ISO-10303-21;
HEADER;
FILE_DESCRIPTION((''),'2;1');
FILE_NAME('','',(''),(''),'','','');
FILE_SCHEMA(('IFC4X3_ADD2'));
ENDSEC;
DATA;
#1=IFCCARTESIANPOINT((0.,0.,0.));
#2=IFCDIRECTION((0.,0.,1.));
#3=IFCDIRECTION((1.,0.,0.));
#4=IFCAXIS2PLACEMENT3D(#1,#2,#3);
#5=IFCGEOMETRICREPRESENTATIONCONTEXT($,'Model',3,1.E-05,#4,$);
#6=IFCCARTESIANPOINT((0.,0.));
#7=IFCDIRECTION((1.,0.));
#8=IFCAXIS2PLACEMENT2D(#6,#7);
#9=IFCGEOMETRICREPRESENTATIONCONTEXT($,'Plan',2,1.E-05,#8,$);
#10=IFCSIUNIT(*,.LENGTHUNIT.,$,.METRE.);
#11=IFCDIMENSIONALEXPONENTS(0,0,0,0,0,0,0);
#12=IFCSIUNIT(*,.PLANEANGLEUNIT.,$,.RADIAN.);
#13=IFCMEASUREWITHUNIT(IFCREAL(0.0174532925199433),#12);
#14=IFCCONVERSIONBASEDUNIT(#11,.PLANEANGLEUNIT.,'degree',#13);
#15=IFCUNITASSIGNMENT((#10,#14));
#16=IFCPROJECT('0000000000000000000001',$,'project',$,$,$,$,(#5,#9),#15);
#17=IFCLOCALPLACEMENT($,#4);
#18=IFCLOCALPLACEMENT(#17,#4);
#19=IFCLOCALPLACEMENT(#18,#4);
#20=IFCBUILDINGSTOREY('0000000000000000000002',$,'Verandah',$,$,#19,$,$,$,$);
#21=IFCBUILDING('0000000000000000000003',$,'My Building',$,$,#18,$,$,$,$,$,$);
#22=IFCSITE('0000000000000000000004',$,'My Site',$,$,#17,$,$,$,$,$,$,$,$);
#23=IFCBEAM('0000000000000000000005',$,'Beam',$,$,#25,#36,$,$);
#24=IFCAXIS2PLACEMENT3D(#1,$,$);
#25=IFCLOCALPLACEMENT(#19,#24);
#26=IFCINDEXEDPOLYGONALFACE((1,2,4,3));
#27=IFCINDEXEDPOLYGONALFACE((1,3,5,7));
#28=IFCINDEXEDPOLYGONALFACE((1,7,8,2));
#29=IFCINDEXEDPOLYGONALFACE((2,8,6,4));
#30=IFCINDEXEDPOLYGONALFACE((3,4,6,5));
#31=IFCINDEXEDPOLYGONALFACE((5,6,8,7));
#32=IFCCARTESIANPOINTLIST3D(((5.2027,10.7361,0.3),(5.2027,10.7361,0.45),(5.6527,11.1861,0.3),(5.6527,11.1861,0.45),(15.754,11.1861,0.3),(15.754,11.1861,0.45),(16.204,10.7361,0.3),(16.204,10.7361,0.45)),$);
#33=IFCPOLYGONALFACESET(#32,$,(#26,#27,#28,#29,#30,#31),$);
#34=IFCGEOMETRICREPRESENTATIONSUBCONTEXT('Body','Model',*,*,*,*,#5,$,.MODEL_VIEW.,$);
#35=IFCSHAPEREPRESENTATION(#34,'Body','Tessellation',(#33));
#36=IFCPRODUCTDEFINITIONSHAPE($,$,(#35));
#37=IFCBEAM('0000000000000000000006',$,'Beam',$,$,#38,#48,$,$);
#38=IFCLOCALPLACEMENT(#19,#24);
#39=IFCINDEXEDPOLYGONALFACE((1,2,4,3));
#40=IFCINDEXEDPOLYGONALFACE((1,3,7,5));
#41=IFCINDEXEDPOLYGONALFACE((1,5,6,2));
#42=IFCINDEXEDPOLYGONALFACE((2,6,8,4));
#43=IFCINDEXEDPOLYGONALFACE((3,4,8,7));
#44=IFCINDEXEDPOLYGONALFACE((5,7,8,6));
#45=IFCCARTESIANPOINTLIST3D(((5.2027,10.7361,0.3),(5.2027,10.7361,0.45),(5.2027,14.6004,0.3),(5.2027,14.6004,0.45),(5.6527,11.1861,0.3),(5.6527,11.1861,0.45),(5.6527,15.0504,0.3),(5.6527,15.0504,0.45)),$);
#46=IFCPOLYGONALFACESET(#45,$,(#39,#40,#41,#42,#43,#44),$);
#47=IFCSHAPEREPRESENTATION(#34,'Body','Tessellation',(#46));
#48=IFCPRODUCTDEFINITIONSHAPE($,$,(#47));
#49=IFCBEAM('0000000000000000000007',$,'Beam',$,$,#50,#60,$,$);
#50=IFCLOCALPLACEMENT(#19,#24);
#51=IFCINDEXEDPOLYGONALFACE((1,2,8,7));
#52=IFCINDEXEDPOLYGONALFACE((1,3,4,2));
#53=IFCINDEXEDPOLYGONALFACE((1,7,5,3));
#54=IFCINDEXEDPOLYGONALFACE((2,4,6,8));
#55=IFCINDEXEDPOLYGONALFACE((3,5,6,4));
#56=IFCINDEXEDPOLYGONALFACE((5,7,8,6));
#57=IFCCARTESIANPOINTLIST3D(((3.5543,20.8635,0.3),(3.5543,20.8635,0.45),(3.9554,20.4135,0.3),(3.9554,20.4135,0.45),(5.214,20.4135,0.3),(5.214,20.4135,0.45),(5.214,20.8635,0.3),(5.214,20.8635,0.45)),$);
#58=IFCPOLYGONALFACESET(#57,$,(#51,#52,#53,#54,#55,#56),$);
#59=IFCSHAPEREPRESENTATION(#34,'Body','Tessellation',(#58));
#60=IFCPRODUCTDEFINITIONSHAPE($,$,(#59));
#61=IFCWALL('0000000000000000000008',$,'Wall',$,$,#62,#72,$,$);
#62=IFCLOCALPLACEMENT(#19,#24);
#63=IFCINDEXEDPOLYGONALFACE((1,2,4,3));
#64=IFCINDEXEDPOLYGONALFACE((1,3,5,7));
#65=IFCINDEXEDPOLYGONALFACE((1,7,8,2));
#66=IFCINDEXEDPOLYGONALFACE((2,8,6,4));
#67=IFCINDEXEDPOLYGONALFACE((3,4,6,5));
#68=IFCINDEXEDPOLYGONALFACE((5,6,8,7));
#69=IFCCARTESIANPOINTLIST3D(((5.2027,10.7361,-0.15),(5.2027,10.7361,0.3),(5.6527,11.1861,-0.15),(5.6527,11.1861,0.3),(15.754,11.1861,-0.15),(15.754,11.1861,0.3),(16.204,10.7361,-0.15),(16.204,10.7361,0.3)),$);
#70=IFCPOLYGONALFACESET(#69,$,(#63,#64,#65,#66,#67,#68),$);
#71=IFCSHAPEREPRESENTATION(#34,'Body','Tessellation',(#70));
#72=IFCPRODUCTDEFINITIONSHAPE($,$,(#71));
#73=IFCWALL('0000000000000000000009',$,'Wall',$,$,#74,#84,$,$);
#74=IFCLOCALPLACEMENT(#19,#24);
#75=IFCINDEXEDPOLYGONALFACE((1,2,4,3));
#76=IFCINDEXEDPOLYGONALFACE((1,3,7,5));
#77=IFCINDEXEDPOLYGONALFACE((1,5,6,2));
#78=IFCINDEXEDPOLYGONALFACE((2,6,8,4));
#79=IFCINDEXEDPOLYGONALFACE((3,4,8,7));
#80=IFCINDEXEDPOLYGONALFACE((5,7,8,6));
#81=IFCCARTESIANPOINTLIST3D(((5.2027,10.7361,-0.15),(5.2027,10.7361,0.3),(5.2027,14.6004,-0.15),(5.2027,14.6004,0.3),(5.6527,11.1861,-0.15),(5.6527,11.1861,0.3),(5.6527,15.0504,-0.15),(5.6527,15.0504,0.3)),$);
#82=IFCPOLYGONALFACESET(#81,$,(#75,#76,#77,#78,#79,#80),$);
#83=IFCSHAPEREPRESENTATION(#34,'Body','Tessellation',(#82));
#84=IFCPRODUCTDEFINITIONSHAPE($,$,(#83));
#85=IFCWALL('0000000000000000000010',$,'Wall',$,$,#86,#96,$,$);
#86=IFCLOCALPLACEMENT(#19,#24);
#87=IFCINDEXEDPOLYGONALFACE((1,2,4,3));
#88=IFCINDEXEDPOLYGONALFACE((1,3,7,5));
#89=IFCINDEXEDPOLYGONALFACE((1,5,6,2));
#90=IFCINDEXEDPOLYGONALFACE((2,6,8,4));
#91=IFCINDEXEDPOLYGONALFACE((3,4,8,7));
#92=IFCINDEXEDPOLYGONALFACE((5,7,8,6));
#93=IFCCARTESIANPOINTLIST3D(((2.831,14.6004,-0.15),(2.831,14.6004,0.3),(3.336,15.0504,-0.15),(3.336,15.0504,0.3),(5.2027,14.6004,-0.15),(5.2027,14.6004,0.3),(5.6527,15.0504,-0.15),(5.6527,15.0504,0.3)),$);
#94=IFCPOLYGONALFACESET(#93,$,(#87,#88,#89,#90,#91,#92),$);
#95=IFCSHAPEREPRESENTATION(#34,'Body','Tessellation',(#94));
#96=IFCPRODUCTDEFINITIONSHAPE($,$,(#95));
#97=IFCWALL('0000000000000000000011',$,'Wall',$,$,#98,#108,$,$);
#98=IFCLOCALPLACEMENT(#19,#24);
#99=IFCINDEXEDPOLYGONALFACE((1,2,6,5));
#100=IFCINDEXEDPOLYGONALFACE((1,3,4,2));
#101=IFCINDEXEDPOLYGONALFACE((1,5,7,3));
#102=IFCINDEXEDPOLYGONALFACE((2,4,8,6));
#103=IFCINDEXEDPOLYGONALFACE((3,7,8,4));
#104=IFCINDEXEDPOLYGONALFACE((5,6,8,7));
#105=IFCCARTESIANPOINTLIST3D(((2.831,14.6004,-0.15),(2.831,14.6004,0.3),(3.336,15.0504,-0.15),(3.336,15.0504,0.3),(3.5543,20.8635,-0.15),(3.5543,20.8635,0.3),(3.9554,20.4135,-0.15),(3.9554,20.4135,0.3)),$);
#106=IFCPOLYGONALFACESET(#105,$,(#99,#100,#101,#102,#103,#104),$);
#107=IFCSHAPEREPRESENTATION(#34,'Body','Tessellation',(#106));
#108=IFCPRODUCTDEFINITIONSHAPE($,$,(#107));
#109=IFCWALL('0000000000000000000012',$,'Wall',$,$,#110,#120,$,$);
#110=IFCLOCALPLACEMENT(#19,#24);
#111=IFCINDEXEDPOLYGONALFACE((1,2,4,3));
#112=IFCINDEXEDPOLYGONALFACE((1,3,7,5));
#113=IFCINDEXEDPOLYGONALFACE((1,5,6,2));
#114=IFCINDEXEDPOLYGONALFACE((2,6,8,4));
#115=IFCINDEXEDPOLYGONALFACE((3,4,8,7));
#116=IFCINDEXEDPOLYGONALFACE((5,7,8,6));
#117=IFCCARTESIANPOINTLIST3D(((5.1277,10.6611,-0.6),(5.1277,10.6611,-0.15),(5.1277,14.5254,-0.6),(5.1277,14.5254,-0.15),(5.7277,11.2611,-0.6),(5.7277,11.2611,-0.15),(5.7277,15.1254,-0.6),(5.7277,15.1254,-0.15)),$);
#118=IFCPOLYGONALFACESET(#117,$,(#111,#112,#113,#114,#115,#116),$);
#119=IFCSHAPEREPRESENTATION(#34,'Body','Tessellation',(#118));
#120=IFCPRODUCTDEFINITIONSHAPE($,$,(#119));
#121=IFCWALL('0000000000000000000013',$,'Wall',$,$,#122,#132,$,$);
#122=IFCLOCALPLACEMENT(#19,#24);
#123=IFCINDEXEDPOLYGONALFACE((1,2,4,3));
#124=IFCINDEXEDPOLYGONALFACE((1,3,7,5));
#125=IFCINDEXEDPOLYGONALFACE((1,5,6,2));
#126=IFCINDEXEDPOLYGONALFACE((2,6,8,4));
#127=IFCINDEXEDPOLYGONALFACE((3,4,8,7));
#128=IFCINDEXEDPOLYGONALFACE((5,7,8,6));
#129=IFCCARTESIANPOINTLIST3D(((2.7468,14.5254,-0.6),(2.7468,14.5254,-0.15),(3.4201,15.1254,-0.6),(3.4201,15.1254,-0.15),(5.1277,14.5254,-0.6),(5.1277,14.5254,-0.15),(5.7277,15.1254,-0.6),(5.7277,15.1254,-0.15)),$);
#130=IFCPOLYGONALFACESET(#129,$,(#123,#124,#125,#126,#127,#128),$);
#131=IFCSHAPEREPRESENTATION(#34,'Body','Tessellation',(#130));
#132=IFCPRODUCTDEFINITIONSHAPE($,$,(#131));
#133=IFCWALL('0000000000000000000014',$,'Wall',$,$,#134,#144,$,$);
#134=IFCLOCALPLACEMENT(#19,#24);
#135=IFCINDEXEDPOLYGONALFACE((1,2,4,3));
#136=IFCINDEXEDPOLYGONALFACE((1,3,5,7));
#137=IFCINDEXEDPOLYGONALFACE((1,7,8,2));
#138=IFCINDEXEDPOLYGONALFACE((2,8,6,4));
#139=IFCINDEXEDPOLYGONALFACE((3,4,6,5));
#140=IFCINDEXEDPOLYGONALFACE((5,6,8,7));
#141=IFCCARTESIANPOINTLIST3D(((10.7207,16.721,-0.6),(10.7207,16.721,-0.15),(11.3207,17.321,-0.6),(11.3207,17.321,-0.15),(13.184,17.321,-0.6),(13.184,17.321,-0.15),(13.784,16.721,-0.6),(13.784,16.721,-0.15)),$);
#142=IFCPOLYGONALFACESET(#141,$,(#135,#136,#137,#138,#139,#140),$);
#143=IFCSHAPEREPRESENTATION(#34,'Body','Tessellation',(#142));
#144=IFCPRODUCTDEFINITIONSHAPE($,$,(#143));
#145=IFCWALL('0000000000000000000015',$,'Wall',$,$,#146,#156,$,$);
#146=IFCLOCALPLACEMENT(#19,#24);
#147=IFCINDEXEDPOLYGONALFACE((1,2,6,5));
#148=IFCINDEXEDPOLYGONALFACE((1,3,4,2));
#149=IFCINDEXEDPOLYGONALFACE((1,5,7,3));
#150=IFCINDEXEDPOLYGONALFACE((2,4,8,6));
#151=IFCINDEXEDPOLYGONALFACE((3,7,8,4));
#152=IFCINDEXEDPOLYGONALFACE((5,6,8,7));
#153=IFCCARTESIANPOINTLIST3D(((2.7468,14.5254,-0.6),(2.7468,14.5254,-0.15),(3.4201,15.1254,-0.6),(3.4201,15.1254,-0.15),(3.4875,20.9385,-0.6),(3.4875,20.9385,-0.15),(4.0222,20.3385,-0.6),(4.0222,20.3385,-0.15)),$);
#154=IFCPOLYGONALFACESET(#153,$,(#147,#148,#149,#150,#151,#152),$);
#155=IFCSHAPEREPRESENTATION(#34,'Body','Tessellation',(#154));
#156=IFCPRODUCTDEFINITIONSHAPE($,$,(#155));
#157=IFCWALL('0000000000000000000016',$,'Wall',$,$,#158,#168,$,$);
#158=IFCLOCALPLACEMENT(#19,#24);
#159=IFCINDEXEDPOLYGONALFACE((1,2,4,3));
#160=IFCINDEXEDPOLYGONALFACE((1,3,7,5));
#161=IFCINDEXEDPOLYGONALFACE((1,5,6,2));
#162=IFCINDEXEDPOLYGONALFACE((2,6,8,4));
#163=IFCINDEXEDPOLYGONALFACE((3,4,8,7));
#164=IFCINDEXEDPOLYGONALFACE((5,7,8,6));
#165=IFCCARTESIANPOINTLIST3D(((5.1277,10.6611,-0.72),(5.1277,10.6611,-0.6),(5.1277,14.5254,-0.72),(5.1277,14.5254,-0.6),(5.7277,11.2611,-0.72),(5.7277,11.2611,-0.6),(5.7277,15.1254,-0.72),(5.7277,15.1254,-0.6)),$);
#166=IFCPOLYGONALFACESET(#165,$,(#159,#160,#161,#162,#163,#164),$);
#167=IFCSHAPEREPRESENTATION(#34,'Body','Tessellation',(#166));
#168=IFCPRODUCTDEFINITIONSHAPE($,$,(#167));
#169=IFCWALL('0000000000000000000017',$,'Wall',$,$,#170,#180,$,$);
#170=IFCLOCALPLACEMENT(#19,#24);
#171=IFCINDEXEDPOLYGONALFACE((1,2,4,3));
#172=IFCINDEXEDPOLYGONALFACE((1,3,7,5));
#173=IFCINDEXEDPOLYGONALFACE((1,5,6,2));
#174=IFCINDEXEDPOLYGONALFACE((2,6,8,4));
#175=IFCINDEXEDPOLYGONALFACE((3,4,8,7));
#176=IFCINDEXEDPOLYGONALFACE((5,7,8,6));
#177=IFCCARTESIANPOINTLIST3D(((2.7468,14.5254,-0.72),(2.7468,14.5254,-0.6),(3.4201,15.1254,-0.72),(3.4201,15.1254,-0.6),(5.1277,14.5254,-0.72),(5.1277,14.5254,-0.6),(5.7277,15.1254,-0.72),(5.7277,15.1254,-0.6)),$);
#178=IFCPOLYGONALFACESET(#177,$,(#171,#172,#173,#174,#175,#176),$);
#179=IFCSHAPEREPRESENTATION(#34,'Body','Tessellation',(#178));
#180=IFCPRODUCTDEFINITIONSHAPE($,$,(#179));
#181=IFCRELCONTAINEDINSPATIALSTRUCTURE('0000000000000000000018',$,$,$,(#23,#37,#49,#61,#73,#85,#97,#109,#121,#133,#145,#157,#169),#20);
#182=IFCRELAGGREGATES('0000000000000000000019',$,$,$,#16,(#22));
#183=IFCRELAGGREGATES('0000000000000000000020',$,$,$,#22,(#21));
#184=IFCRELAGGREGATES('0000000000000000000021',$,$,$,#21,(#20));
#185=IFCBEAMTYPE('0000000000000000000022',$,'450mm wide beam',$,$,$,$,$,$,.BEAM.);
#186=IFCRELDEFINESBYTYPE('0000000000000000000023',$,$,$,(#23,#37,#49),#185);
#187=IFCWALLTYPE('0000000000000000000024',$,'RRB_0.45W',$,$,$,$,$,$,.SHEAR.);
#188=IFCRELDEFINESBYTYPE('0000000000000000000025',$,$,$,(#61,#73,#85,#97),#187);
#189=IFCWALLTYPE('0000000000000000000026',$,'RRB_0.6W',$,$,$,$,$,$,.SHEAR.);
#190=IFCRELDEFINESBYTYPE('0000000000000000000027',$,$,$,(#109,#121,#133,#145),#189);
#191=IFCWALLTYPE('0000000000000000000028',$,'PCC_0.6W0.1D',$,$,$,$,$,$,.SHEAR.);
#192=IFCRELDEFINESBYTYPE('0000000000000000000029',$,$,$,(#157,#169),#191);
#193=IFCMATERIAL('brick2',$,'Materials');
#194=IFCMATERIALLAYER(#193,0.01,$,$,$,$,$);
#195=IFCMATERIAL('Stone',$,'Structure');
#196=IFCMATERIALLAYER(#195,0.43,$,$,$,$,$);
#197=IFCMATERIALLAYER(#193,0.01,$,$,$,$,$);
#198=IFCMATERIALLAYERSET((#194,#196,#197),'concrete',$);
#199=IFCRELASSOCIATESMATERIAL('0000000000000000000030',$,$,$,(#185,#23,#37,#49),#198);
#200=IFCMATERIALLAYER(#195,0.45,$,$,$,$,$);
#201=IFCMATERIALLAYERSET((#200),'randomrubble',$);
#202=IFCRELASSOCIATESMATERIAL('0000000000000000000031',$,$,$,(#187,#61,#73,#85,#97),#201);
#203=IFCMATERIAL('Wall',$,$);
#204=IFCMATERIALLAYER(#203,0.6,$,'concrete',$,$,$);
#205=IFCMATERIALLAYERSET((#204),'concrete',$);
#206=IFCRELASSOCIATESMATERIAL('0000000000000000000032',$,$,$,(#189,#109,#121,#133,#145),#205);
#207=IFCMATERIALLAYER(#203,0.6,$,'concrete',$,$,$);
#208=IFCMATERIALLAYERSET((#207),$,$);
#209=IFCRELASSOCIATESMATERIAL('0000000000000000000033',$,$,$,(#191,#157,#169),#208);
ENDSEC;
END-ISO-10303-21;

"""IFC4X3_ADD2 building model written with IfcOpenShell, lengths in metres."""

from ifc_helpers import new_model, entity, si_unit, converted_unit, frame, origin_with_axes, origin_2d_with_axis, place, context, subcontext, project, spatial, line, indexed_curve, outline, extrude, material, layer, layer_set, layer_usage, type_object, element, save


model = new_model("IFC4X3_ADD2")

# Units and contexts
model_context = context("Model", 3, precision=1e-05, world=origin_with_axes())
plan_context = context("Plan", 2, precision=1e-05, world=origin_2d_with_axis())
body_context = subcontext(model_context, "Body", "Model", "MODEL_VIEW")
ifc_project = project(units=[si_unit("LENGTHUNIT", "METRE"), converted_unit("PLANEANGLEUNIT", "degree", entity("IfcReal", 0.0174532925199433), si_unit("PLANEANGLEUNIT", "RADIAN"), dimensions=[0, 0, 0, 0, 0, 0, 0])], contexts=[model_context, plan_context])

# Site, building, storey
site_placement = place(None, origin_with_axes())
site = spatial("IfcSite", under=ifc_project, at=site_placement, Name="My Site")
building_placement = place(site_placement, origin_with_axes())
building = spatial("IfcBuilding", under=site, at=building_placement, Name="My Building")
storey_placement = place(building_placement, origin_with_axes())
storey = spatial("IfcBuildingStorey", under=building, at=storey_placement, Name="Verandah")

# Beams
ifc_material_1 = material(Name="brick2", Category="Materials")
ifc_layer_1 = layer(ifc_material_1, 0.01)
ifc_material_2 = material(Name="Stone", Category="Structure")
ifc_layer_2 = layer(ifc_material_2, 0.43)
ifc_layer_3 = layer(ifc_material_1, 0.01)
ifc_layer_set_1 = layer_set([ifc_layer_1, ifc_layer_2, ifc_layer_3], Name="concrete")
ifc_layer_usage_1 = layer_usage(ifc_layer_set_1, "AXIS2", "POSITIVE", 0.0)
beam_type = type_object("IfcBeamType", Name="450mm wide beam", PredefinedType="BEAM", material=ifc_layer_set_1)
beam_1_placement = place(storey_placement, frame((5.2027, 10.7361, 0.3), z_axis=(0.0, 0.0, 1.0), x_axis=(1.0, 0.0, 0.0)))
element("IfcBeam", 1, at=beam_1_placement, inside=storey, type_object=beam_type, material=ifc_layer_usage_1, Name="Beam", context=body_context, shape_type="SweptSolid", body=[
    extrude(outline(indexed_curve([(0.0, 0.0), (0.45, 0.45), (10.5513, 0.45), (11.0013, 0.0)], segments=[line(1, 2, 3, 4, 1)])), origin_with_axes(), (0.0, 0.0, 1.0), 0.15),
])
ifc_layer_usage_2 = layer_usage(ifc_layer_set_1, "AXIS2", "POSITIVE", 0.0)
beam_2_placement = place(storey_placement, frame((5.2027, 14.6004, 0.3), z_axis=(0.0, 0.0, 1.0), x_axis=(0.0, -1.0, 0.0)))
element("IfcBeam", 2, at=beam_2_placement, inside=storey, type_object=beam_type, material=ifc_layer_usage_2, Name="Beam", context=body_context, shape_type="SweptSolid", body=[
    extrude(outline(indexed_curve([(0.0, 0.0), (-0.45, 0.45), (3.4142, 0.45), (3.8642, 0.0)], segments=[line(1, 2, 3, 4, 1)])), origin_with_axes(), (0.0, 0.0, 1.0), 0.15),
])
ifc_layer_usage_3 = layer_usage(ifc_layer_set_1, "AXIS2", "POSITIVE", 0.0)
beam_3_placement = place(storey_placement, frame((3.9554, 20.4135, 0.3), z_axis=(0.0, 0.0, 1.0), x_axis=(1.0, 0.0, 0.0)))
element("IfcBeam", 3, at=beam_3_placement, inside=storey, type_object=beam_type, material=ifc_layer_usage_3, Name="Beam", context=body_context, shape_type="SweptSolid", body=[
    extrude(outline(indexed_curve([(0.0, 0.0), (-0.401, 0.45), (1.2587, 0.45), (1.2587, 0.0)], segments=[line(1, 2, 3, 4, 1)])), origin_with_axes(), (0.0, 0.0, 1.0), 0.15),
])

# Walls
ifc_layer_4 = layer(ifc_material_2, 0.45)
ifc_layer_set_2 = layer_set([ifc_layer_4], Name="randomrubble")
ifc_layer_usage_4 = layer_usage(ifc_layer_set_2, "AXIS2", "POSITIVE", 0.0)
wall_type_1 = type_object("IfcWallType", Name="RRB_0.45W", PredefinedType="SHEAR", material=ifc_layer_set_2)
wall_1_placement = place(storey_placement, frame((5.6527, 10.7361, -0.15), z_axis=(0.0, 0.0, 1.0), x_axis=(1.0, -0.000001, 0.0)))
element("IfcWall", 4, at=wall_1_placement, inside=storey, type_object=wall_type_1, material=ifc_layer_usage_4, Name="Wall", context=body_context, shape_type="SweptSolid", body=[
    extrude(outline(indexed_curve([(-0.45, 0.0), (0.0, 0.45), (10.1013, 0.45), (10.5513, 0.0)], segments=[line(1, 2, 3, 4, 1)])), origin_with_axes(), (0.0, 0.0, 1.0), 0.45),
])
ifc_layer_usage_5 = layer_usage(ifc_layer_set_2, "AXIS2", "POSITIVE", 0.0)
wall_2_placement = place(storey_placement, frame((5.6527, 10.7361, -0.15), z_axis=(0.0, 0.0, 1.0), x_axis=(0.000001, 1.0, 0.0)))
element("IfcWall", 5, at=wall_2_placement, inside=storey, type_object=wall_type_1, material=ifc_layer_usage_5, Name="Wall", context=body_context, shape_type="SweptSolid", body=[
    extrude(outline(indexed_curve([(0.45, 0.0), (0.0, 0.45), (3.8642, 0.45), (4.3142, 0.0)], segments=[line(1, 2, 3, 4, 1)])), origin_with_axes(), (0.0, 0.0, 1.0), 0.45),
])
ifc_layer_usage_6 = layer_usage(ifc_layer_set_2, "AXIS2", "POSITIVE", 0.0)
wall_3_placement = place(storey_placement, frame((5.6527, 15.0504, -0.15), z_axis=(0.0, 0.0, 1.0), x_axis=(-1.0, 0.000001, 0.0)))
element("IfcWall", 6, at=wall_3_placement, inside=storey, type_object=wall_type_1, material=ifc_layer_usage_6, Name="Wall", context=body_context, shape_type="SweptSolid", body=[
    extrude(outline(indexed_curve([(0.0, 0.0), (0.45, 0.45), (2.8217, 0.45), (2.3167, 0.0)], segments=[line(1, 2, 3, 4, 1)])), origin_with_axes(), (0.0, 0.0, 1.0), 0.45),
])
ifc_layer_usage_7 = layer_usage(ifc_layer_set_2, "AXIS2", "POSITIVE", 0.0)
wall_4_placement = place(storey_placement, frame((3.5543, 20.8635, -0.15), z_axis=(0.0, 0.0, 1.0), x_axis=(-0.114729, -0.993397, 0.0)))
element("IfcWall", 7, at=wall_4_placement, inside=storey, type_object=wall_type_1, material=ifc_layer_usage_7, Name="Wall", context=body_context, shape_type="SweptSolid", body=[
    extrude(outline(indexed_curve([(0.0, 0.0), (0.401, 0.45), (5.7998, 0.45), (6.3047, 0.0)], segments=[line(1, 2, 3, 4, 1)])), origin_with_axes(), (0.0, 0.0, 1.0), 0.45),
])
ifc_material_3 = material(Name="Wall")
ifc_layer_5 = layer(ifc_material_3, 0.6, Name="concrete")
ifc_layer_set_3 = layer_set([ifc_layer_5], Name="concrete")
ifc_layer_usage_8 = layer_usage(ifc_layer_set_3, "AXIS2", "POSITIVE", 0.0)
wall_type_2 = type_object("IfcWallType", Name="RRB_0.6W", PredefinedType="SHEAR", material=ifc_layer_set_3)
wall_5_placement = place(storey_placement, frame((5.1277, 15.1254, -0.6), z_axis=(0.0, 0.0, 1.0), x_axis=(-0.000001, -1.0, 0.0)))
element("IfcWall", 8, at=wall_5_placement, inside=storey, type_object=wall_type_2, material=ifc_layer_usage_8, Name="Wall", context=body_context, shape_type="SweptSolid", body=[
    extrude(outline(indexed_curve([(0.6, 0.0), (0.0, 0.6), (3.8642, 0.6), (4.4642, 0.0)], segments=[line(1, 2, 3, 4, 1)])), origin_with_axes(), (0.0, 0.0, 1.0), 0.45),
])
ifc_layer_usage_9 = layer_usage(ifc_layer_set_3, "AXIS2", "POSITIVE", 0.0)
wall_6_placement = place(storey_placement, frame((5.1277, 15.1254, -0.6), z_axis=(0.0, 0.0, 1.0), x_axis=(-1.0, 0.000001, 0.0)))
element("IfcWall", 9, at=wall_6_placement, inside=storey, type_object=wall_type_2, material=ifc_layer_usage_9, Name="Wall", context=body_context, shape_type="SweptSolid", body=[
    extrude(outline(indexed_curve([(-0.6, 0.0), (0.0, 0.6), (2.3809, 0.6), (1.7076, 0.0)], segments=[line(1, 2, 3, 4, 1)])), origin_with_axes(), (0.0, 0.0, 1.0), 0.45),
])
ifc_layer_usage_10 = layer_usage(ifc_layer_set_3, "AXIS2", "POSITIVE", 0.0)
wall_7_placement = place(storey_placement, frame((10.7207, 16.721, -0.6), z_axis=(0.0, 0.0, 1.0), x_axis=(1.0, 0.0, 0.0)))
element("IfcWall", 10, at=wall_7_placement, inside=storey, type_object=wall_type_2, material=ifc_layer_usage_10, Name="Wall", context=body_context, shape_type="SweptSolid", body=[
    extrude(outline(indexed_curve([(0.0, 0.0), (0.6, 0.6), (2.4633, 0.6), (3.0633, 0.0)], segments=[line(1, 2, 3, 4, 1)])), origin_with_axes(), (0.0, 0.0, 1.0), 0.45),
])
ifc_layer_usage_11 = layer_usage(ifc_layer_set_3, "AXIS2", "POSITIVE", 0.0)
wall_8_placement = place(storey_placement, frame((3.4875, 20.9385, -0.6), z_axis=(0.0, 0.0, 1.0), x_axis=(-0.114729, -0.993397, 0.0)))
element("IfcWall", 11, at=wall_8_placement, inside=storey, type_object=wall_type_2, material=ifc_layer_usage_11, Name="Wall", context=body_context, shape_type="SweptSolid", body=[
    extrude(outline(indexed_curve([(0.0, 0.0), (0.5347, 0.6), (5.7825, 0.6), (6.4557, 0.0)], segments=[line(1, 2, 3, 4, 1)])), origin_with_axes(), (0.0, 0.0, 1.0), 0.45),
])
ifc_layer_6 = layer(ifc_material_3, 0.6, Name="concrete")
ifc_layer_set_4 = layer_set([ifc_layer_6])
ifc_layer_usage_12 = layer_usage(ifc_layer_set_4, "AXIS2", "POSITIVE", 0.0)
wall_type_3 = type_object("IfcWallType", Name="PCC_0.6W0.1D", PredefinedType="SHEAR", material=ifc_layer_set_4)
wall_9_placement = place(storey_placement, frame((5.1277, 15.1254, -0.72), z_axis=(0.0, 0.0, 1.0), x_axis=(-0.000001, -1.0, 0.0)))
element("IfcWall", 12, at=wall_9_placement, inside=storey, type_object=wall_type_3, material=ifc_layer_usage_12, Name="Wall", context=body_context, shape_type="SweptSolid", body=[
    extrude(outline(indexed_curve([(0.6, 0.0), (0.0, 0.6), (3.8642, 0.6), (4.4642, 0.0)], segments=[line(1, 2, 3, 4, 1)])), origin_with_axes(), (0.0, 0.0, 1.0), 0.12),
])
ifc_layer_usage_13 = layer_usage(ifc_layer_set_4, "AXIS2", "POSITIVE", 0.0)
wall_10_placement = place(storey_placement, frame((5.1277, 15.1254, -0.72), z_axis=(0.0, 0.0, 1.0), x_axis=(-1.0, 0.000001, 0.0)))
element("IfcWall", 13, at=wall_10_placement, inside=storey, type_object=wall_type_3, material=ifc_layer_usage_13, Name="Wall", context=body_context, shape_type="SweptSolid", body=[
    extrude(outline(indexed_curve([(-0.6, 0.0), (0.0, 0.6), (2.3809, 0.6), (1.7076, 0.0)], segments=[line(1, 2, 3, 4, 1)])), origin_with_axes(), (0.0, 0.0, 1.0), 0.12),
])

save(model, "model.ifc")
